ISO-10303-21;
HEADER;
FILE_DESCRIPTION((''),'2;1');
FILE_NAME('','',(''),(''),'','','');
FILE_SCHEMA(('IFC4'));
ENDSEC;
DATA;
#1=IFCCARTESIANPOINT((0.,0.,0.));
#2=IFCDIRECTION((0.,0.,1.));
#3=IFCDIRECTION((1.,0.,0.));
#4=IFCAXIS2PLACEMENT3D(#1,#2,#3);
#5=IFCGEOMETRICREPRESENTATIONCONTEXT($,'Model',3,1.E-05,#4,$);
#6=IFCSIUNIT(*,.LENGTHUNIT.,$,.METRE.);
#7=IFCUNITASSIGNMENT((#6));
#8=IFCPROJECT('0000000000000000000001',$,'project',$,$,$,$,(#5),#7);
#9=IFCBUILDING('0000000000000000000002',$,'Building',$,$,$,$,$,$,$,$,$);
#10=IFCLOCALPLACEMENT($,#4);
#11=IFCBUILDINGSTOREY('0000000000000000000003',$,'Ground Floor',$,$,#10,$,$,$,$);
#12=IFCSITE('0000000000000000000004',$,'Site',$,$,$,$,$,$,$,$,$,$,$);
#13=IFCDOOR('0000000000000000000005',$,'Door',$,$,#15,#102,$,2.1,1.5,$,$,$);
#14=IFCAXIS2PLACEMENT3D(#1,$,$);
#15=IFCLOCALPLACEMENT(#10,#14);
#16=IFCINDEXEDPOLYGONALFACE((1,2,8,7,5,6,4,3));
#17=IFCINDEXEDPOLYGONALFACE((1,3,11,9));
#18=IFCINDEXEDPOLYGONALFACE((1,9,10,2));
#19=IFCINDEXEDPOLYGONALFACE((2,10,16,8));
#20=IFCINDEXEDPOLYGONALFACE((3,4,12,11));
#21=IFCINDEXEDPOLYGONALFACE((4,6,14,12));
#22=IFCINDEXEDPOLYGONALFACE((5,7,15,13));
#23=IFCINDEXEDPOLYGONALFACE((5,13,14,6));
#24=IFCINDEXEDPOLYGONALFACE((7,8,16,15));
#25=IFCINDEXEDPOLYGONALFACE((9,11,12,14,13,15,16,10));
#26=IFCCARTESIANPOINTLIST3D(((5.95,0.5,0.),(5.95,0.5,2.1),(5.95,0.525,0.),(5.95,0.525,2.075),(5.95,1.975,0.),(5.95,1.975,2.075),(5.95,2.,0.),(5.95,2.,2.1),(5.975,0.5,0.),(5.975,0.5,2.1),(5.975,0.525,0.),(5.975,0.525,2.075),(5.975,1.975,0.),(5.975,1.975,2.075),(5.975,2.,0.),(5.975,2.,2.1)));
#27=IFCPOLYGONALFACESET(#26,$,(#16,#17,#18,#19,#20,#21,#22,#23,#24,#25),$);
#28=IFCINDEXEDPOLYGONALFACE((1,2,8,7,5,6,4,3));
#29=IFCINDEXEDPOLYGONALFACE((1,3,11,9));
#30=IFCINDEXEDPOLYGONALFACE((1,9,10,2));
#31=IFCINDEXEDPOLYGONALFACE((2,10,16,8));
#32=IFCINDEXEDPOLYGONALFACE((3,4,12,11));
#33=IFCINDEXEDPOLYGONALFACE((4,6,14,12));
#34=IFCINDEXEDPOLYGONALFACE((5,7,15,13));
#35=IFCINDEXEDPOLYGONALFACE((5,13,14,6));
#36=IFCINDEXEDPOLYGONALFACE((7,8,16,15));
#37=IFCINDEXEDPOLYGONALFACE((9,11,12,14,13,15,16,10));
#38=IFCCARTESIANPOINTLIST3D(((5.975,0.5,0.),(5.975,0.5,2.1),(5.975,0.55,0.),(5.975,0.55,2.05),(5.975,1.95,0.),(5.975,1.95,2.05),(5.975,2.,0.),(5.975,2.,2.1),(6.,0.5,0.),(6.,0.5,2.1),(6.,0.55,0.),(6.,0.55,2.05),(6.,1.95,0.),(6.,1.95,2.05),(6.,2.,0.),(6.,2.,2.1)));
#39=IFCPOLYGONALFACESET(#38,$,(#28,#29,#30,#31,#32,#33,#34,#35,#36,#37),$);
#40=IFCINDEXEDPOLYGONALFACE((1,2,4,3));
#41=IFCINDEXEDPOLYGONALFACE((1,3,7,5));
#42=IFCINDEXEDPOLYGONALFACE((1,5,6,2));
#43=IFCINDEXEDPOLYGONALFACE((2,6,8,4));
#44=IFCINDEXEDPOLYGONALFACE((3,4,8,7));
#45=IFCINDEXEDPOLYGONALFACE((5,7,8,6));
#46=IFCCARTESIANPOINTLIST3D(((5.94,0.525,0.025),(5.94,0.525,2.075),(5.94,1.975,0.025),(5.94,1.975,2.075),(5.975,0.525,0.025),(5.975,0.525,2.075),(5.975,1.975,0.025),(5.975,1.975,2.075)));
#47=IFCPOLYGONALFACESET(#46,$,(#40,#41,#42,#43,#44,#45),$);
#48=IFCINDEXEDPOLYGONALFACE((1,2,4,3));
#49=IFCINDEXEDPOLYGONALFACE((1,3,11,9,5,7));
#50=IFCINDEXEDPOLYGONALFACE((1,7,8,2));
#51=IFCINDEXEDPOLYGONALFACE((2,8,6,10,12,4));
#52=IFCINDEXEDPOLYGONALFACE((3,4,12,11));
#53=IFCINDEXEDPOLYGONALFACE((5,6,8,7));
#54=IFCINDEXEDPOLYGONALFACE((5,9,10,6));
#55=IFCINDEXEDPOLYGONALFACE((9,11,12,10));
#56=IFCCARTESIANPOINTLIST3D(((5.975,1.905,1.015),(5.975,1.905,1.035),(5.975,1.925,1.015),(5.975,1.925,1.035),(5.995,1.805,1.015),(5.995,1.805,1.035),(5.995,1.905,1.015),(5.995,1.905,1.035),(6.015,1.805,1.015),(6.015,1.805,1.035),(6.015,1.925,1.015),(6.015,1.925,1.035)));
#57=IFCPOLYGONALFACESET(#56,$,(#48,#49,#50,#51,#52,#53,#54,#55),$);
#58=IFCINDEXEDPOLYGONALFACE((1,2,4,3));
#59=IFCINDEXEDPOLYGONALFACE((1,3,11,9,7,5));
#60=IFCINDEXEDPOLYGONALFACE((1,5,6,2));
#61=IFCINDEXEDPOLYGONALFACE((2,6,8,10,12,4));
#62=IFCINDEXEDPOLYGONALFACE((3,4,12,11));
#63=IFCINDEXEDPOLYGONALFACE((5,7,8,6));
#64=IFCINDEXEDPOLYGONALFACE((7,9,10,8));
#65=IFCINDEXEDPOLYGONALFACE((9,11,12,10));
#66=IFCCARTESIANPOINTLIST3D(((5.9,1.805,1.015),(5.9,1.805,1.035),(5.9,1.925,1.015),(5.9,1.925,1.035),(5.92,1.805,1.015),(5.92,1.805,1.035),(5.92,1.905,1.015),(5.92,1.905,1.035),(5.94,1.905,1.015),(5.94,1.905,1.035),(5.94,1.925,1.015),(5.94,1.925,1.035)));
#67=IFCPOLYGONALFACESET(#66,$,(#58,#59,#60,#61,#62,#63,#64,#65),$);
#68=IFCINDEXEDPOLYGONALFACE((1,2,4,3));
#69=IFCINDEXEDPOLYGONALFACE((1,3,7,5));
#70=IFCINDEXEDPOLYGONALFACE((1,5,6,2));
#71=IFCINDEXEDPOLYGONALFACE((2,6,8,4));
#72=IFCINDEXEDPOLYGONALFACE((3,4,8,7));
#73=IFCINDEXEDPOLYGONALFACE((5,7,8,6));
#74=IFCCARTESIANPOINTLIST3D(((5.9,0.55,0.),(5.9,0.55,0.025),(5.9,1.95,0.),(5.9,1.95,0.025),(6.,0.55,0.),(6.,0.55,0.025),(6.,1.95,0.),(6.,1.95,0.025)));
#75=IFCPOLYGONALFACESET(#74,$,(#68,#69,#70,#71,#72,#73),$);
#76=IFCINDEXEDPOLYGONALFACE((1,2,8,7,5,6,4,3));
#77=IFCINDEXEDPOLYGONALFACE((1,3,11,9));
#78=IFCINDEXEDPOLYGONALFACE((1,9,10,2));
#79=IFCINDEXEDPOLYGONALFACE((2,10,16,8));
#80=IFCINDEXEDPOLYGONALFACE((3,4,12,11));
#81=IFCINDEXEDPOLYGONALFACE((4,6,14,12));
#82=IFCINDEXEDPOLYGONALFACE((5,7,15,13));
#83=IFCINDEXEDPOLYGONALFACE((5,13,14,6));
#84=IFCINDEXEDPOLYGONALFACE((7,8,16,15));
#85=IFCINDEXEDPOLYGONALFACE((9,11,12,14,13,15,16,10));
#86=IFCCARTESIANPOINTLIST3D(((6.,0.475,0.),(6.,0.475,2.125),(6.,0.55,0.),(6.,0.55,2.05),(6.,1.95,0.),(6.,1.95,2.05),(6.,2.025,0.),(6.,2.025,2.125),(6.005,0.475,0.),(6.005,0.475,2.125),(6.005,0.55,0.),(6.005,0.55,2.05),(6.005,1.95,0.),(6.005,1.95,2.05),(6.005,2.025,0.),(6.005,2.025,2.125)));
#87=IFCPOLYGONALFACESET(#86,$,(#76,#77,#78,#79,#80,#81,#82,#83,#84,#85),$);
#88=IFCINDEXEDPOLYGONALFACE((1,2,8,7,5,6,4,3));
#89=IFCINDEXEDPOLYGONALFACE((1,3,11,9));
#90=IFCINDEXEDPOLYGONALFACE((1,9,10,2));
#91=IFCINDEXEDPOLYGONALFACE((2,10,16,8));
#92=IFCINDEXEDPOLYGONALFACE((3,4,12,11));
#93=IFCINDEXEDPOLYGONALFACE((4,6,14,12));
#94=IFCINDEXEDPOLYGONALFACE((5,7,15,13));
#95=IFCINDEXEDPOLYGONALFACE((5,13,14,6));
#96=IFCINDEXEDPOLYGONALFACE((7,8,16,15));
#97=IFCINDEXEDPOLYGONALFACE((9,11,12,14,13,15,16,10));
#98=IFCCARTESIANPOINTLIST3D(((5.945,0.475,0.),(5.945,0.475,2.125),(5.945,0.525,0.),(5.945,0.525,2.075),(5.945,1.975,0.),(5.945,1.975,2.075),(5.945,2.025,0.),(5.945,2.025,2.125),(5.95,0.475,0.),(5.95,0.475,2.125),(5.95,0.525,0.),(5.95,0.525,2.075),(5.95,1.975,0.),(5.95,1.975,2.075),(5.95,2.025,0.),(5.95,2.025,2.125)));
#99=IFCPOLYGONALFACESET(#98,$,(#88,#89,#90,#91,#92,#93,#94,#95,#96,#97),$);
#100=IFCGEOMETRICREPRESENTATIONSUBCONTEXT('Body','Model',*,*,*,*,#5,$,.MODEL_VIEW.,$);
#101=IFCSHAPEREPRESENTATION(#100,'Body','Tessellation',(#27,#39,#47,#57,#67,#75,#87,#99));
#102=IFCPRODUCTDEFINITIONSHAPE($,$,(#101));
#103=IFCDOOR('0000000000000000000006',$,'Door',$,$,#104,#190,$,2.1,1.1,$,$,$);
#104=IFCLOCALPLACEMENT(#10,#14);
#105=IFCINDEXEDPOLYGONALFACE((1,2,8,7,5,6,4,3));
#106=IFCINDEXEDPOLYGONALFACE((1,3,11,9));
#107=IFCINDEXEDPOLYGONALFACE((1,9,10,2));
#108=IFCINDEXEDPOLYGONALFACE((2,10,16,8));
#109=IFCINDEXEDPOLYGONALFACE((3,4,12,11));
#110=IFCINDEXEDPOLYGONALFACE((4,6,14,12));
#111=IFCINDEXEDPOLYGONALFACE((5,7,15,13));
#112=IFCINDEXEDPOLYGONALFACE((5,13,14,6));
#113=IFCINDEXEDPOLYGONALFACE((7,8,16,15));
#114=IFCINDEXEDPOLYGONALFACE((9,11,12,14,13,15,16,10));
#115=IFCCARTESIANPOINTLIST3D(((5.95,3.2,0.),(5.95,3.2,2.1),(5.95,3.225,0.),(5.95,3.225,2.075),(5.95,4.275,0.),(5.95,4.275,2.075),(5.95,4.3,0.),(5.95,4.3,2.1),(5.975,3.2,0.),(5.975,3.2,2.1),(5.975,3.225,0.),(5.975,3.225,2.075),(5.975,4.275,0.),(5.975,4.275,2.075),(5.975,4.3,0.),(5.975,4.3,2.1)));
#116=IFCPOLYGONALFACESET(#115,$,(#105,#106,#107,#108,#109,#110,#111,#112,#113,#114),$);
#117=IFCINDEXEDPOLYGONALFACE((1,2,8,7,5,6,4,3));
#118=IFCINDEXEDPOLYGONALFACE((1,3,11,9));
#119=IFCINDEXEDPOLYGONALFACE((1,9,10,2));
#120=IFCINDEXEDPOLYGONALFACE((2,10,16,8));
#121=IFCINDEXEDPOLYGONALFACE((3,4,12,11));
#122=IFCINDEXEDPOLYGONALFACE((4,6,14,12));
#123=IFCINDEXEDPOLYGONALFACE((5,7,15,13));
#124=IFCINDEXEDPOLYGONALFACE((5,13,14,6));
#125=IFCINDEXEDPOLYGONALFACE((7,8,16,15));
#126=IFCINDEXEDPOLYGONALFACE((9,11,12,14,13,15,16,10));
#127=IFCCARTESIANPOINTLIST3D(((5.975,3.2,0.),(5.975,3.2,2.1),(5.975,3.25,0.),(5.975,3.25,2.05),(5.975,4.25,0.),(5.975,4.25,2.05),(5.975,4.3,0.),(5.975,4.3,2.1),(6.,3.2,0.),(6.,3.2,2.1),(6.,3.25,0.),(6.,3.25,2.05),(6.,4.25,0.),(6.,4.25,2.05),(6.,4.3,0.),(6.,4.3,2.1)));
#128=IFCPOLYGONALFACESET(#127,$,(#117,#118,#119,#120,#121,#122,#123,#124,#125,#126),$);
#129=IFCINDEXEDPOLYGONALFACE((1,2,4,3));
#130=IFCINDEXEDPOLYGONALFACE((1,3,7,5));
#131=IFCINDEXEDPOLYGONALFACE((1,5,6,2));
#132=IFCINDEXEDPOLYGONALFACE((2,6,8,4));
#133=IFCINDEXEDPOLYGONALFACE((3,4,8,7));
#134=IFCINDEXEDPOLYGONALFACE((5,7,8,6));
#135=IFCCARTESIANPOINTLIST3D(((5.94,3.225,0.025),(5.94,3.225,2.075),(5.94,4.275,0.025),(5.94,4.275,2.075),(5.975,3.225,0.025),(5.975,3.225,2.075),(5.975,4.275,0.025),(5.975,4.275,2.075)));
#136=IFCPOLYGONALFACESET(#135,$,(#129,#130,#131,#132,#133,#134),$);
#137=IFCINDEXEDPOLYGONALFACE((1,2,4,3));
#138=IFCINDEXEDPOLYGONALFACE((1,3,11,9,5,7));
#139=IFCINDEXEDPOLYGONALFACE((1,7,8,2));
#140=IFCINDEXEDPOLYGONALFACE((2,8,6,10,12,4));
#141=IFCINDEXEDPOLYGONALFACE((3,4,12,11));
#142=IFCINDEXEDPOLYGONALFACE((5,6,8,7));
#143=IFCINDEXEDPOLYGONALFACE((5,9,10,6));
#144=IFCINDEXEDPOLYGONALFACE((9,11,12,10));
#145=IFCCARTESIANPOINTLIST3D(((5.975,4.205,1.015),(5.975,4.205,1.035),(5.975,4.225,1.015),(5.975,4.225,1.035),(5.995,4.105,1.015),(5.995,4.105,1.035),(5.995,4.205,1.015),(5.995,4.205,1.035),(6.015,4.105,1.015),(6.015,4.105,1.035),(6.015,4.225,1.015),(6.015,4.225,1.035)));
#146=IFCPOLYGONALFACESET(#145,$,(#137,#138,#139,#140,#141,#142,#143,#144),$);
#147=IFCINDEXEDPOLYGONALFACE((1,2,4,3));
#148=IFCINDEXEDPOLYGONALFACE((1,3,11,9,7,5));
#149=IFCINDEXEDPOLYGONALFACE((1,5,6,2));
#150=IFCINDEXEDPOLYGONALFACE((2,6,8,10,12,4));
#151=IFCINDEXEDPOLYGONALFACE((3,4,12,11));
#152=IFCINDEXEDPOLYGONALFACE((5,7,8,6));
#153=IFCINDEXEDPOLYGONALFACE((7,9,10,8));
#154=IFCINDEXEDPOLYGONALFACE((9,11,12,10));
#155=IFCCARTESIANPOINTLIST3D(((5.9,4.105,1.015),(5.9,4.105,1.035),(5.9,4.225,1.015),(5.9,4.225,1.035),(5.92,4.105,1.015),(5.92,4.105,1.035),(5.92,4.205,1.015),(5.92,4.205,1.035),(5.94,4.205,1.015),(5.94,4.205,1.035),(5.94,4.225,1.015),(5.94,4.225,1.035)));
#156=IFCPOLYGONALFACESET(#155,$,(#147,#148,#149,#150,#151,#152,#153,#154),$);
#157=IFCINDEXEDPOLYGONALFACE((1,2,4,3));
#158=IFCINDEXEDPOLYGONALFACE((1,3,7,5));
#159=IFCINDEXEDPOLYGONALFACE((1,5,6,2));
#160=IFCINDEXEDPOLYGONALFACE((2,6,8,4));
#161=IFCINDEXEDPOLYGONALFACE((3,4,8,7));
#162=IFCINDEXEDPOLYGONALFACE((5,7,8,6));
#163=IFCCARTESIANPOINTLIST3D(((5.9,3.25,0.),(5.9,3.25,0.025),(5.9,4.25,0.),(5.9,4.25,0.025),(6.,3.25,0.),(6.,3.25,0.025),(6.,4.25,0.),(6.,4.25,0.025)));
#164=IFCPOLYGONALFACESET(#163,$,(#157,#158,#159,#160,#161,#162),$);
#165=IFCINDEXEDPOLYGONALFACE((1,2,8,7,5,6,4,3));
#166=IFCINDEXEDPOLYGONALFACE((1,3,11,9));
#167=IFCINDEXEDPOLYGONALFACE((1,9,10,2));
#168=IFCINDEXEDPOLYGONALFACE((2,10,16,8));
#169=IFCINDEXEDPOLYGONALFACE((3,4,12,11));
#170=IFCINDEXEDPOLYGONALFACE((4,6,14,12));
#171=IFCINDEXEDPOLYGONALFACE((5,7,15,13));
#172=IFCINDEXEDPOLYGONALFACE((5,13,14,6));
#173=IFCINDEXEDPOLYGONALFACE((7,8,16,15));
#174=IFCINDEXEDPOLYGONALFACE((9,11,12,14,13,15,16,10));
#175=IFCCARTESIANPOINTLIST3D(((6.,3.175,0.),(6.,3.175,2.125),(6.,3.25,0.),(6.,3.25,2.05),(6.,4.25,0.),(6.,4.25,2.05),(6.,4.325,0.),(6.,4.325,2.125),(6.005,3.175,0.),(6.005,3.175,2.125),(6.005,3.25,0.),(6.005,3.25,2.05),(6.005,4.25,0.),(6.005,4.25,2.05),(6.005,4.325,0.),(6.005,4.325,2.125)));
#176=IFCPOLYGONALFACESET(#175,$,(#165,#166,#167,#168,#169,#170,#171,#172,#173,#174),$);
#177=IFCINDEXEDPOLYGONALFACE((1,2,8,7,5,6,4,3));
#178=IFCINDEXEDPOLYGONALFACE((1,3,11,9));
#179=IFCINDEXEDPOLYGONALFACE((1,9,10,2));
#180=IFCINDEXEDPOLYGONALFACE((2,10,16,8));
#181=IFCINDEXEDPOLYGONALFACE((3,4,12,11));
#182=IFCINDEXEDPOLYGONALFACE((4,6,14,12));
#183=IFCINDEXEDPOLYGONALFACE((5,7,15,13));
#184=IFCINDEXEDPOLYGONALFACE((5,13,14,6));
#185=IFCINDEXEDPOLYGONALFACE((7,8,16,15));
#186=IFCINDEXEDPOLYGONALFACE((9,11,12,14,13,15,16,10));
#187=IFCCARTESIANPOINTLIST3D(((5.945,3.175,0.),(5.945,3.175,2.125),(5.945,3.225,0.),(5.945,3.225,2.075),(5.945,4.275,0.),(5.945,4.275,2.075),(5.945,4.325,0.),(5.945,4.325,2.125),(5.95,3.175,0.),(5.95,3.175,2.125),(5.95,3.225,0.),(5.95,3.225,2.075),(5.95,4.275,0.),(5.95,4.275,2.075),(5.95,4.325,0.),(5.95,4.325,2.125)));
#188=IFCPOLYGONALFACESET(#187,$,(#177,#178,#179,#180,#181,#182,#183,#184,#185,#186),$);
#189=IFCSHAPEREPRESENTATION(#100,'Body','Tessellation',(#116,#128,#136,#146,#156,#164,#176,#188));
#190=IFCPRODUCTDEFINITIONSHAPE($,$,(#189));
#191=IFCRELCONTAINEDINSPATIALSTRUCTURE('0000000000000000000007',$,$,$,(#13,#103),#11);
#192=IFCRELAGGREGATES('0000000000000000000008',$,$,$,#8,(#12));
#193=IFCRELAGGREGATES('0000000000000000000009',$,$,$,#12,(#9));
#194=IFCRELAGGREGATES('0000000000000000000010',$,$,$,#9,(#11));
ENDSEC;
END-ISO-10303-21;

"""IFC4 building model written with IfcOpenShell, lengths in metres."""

from ifc_helpers import new_model, si_unit, frame, origin_with_axes, place, context, subcontext, project, spatial, line, indexed_curve, outline, extrude, element, save


model = new_model("IFC4")

# Units and contexts
model_context = context("Model", 3, precision=1e-05, world=origin_with_axes())
body_context = subcontext(model_context, "Body", "Model", "MODEL_VIEW")
ifc_project = project(units=[si_unit("LENGTHUNIT", "METRE")], contexts=[model_context])

# Site, building, storey
site = spatial("IfcSite", under=ifc_project, Name="Site")
building = spatial("IfcBuilding", under=site, Name="Building")
storey_placement = place(None, origin_with_axes())
storey = spatial("IfcBuildingStorey", under=building, at=storey_placement, Name="Ground Floor")

# Doors
door_1_placement = place(storey_placement, frame((6.0, 0.5, 0.0), z_axis=(0.0, 0.0, 1.0), x_axis=(0.0, 1.0, 0.0)))
element("IfcDoor", 1, at=door_1_placement, inside=storey, Name="Door", OverallHeight=2.1, OverallWidth=1.5, context=body_context, shape_type="SweptSolid", body=[
    extrude(outline(indexed_curve([(0.0, 0.0), (0.0, 2.1), (1.5, 2.1), (1.5, 0.0), (1.475, 0.0), (1.475, 2.075), (0.025, 2.075), (0.025, 0.0)], segments=[line(1, 2, 3, 4, 5, 6, 7, 8, 1)])), frame((0.0, 0.025, 0.0), z_axis=(0.0, -1.0, 0.0), x_axis=(1.0, 0.0, 0.0)), (0.0, 0.0, -1.0), 0.025),
    extrude(outline(indexed_curve([(0.0, 0.0), (0.0, 2.1), (1.5, 2.1), (1.5, 0.0), (1.45, 0.0), (1.45, 2.05), (0.05, 2.05), (0.05, 0.0)], segments=[line(1, 2, 3, 4, 5, 6, 7, 8, 1)])), frame((0.0, 0.0, 0.0), z_axis=(0.0, -1.0, 0.0), x_axis=(1.0, 0.0, 0.0)), (0.0, 0.0, -1.0), 0.025),
    extrude(outline(indexed_curve([(0.0, 0.0), (1.45, 0.0), (1.45, 0.035), (0.0, 0.035)], segments=[line(1, 2, 3, 4, 1)])), frame((0.025, 0.025, 0.025), z_axis=(0.0, 0.0, 1.0), x_axis=(1.0, 0.0, 0.0)), (0.0, 0.0, 1.0), 2.05),
    extrude(outline(indexed_curve([(0.0, 0.0), (0.0, -0.04), (-0.12, -0.04), (-0.12, -0.02), (-0.02, -0.02), (-0.02, 0.0)], segments=[line(1, 2, 3, 4, 5, 6, 1)])), frame((1.425, 0.025, 1.015), z_axis=(0.0, 0.0, 1.0), x_axis=(1.0, 0.0, 0.0)), (0.0, 0.0, 1.0), 0.02),
    extrude(outline(indexed_curve([(0.0, 0.0), (0.0, 0.04), (-0.12, 0.04), (-0.12, 0.02), (-0.02, 0.02), (-0.02, 0.0)], segments=[line(1, 2, 3, 4, 5, 6, 1)])), frame((1.425, 0.06, 1.015), z_axis=(0.0, 0.0, 1.0), x_axis=(1.0, 0.0, 0.0)), (0.0, 0.0, 1.0), 0.02),
    extrude(outline(indexed_curve([(0.0, 0.0), (1.4, 0.0), (1.4, 0.1), (0.0, 0.1)], segments=[line(1, 2, 3, 4, 1)])), frame((0.05, 0.0, 0.0), z_axis=(0.0, 0.0, 1.0), x_axis=(1.0, 0.0, 0.0)), (0.0, 0.0, 1.0), 0.025),
    extrude(outline(indexed_curve([(0.0, 0.0), (0.0, 2.125), (1.55, 2.125), (1.55, 0.0), (1.475, 0.0), (1.475, 2.05), (0.075, 2.05), (0.075, 0.0)], segments=[line(1, 2, 3, 4, 5, 6, 7, 8, 1)])), frame((-0.025, -0.005, 0.0), z_axis=(0.0, -1.0, 0.0), x_axis=(1.0, 0.0, 0.0)), (0.0, 0.0, -1.0), 0.005),
    extrude(outline(indexed_curve([(0.0, 0.0), (0.0, 2.125), (1.55, 2.125), (1.55, 0.0), (1.5, 0.0), (1.5, 2.075), (0.05, 2.075), (0.05, 0.0)], segments=[line(1, 2, 3, 4, 5, 6, 7, 8, 1)])), frame((-0.025, 0.05, 0.0), z_axis=(0.0, -1.0, 0.0), x_axis=(1.0, 0.0, 0.0)), (0.0, 0.0, -1.0), 0.005),
])
door_2_placement = place(storey_placement, frame((6.0, 3.2, 0.0), z_axis=(0.0, 0.0, 1.0), x_axis=(0.0, 1.0, 0.0)))
element("IfcDoor", 2, at=door_2_placement, inside=storey, Name="Door", OverallHeight=2.1, OverallWidth=1.1, context=body_context, shape_type="SweptSolid", body=[
    extrude(outline(indexed_curve([(0.0, 0.0), (0.0, 2.1), (1.1, 2.1), (1.1, 0.0), (1.075, 0.0), (1.075, 2.075), (0.025, 2.075), (0.025, 0.0)], segments=[line(1, 2, 3, 4, 5, 6, 7, 8, 1)])), frame((0.0, 0.025, 0.0), z_axis=(0.0, -1.0, 0.0), x_axis=(1.0, 0.0, 0.0)), (0.0, 0.0, -1.0), 0.025),
    extrude(outline(indexed_curve([(0.0, 0.0), (0.0, 2.1), (1.1, 2.1), (1.1, 0.0), (1.05, 0.0), (1.05, 2.05), (0.05, 2.05), (0.05, 0.0)], segments=[line(1, 2, 3, 4, 5, 6, 7, 8, 1)])), frame((0.0, 0.0, 0.0), z_axis=(0.0, -1.0, 0.0), x_axis=(1.0, 0.0, 0.0)), (0.0, 0.0, -1.0), 0.025),
    extrude(outline(indexed_curve([(0.0, 0.0), (1.05, 0.0), (1.05, 0.035), (0.0, 0.035)], segments=[line(1, 2, 3, 4, 1)])), frame((0.025, 0.025, 0.025), z_axis=(0.0, 0.0, 1.0), x_axis=(1.0, 0.0, 0.0)), (0.0, 0.0, 1.0), 2.05),
    extrude(outline(indexed_curve([(0.0, 0.0), (0.0, -0.04), (-0.12, -0.04), (-0.12, -0.02), (-0.02, -0.02), (-0.02, 0.0)], segments=[line(1, 2, 3, 4, 5, 6, 1)])), frame((1.025, 0.025, 1.015), z_axis=(0.0, 0.0, 1.0), x_axis=(1.0, 0.0, 0.0)), (0.0, 0.0, 1.0), 0.02),
    extrude(outline(indexed_curve([(0.0, 0.0), (0.0, 0.04), (-0.12, 0.04), (-0.12, 0.02), (-0.02, 0.02), (-0.02, 0.0)], segments=[line(1, 2, 3, 4, 5, 6, 1)])), frame((1.025, 0.06, 1.015), z_axis=(0.0, 0.0, 1.0), x_axis=(1.0, 0.0, 0.0)), (0.0, 0.0, 1.0), 0.02),
    extrude(outline(indexed_curve([(0.0, 0.0), (1.0, 0.0), (1.0, 0.1), (0.0, 0.1)], segments=[line(1, 2, 3, 4, 1)])), frame((0.05, 0.0, 0.0), z_axis=(0.0, 0.0, 1.0), x_axis=(1.0, 0.0, 0.0)), (0.0, 0.0, 1.0), 0.025),
    extrude(outline(indexed_curve([(0.0, 0.0), (0.0, 2.125), (1.15, 2.125), (1.15, 0.0), (1.075, 0.0), (1.075, 2.05), (0.075, 2.05), (0.075, 0.0)], segments=[line(1, 2, 3, 4, 5, 6, 7, 8, 1)])), frame((-0.025, -0.005, 0.0), z_axis=(0.0, -1.0, 0.0), x_axis=(1.0, 0.0, 0.0)), (0.0, 0.0, -1.0), 0.005),
    extrude(outline(indexed_curve([(0.0, 0.0), (0.0, 2.125), (1.15, 2.125), (1.15, 0.0), (1.1, 0.0), (1.1, 2.075), (0.05, 2.075), (0.05, 0.0)], segments=[line(1, 2, 3, 4, 5, 6, 7, 8, 1)])), frame((-0.025, 0.05, 0.0), z_axis=(0.0, -1.0, 0.0), x_axis=(1.0, 0.0, 0.0)), (0.0, 0.0, -1.0), 0.005),
])

save(model, "model.ifc")
